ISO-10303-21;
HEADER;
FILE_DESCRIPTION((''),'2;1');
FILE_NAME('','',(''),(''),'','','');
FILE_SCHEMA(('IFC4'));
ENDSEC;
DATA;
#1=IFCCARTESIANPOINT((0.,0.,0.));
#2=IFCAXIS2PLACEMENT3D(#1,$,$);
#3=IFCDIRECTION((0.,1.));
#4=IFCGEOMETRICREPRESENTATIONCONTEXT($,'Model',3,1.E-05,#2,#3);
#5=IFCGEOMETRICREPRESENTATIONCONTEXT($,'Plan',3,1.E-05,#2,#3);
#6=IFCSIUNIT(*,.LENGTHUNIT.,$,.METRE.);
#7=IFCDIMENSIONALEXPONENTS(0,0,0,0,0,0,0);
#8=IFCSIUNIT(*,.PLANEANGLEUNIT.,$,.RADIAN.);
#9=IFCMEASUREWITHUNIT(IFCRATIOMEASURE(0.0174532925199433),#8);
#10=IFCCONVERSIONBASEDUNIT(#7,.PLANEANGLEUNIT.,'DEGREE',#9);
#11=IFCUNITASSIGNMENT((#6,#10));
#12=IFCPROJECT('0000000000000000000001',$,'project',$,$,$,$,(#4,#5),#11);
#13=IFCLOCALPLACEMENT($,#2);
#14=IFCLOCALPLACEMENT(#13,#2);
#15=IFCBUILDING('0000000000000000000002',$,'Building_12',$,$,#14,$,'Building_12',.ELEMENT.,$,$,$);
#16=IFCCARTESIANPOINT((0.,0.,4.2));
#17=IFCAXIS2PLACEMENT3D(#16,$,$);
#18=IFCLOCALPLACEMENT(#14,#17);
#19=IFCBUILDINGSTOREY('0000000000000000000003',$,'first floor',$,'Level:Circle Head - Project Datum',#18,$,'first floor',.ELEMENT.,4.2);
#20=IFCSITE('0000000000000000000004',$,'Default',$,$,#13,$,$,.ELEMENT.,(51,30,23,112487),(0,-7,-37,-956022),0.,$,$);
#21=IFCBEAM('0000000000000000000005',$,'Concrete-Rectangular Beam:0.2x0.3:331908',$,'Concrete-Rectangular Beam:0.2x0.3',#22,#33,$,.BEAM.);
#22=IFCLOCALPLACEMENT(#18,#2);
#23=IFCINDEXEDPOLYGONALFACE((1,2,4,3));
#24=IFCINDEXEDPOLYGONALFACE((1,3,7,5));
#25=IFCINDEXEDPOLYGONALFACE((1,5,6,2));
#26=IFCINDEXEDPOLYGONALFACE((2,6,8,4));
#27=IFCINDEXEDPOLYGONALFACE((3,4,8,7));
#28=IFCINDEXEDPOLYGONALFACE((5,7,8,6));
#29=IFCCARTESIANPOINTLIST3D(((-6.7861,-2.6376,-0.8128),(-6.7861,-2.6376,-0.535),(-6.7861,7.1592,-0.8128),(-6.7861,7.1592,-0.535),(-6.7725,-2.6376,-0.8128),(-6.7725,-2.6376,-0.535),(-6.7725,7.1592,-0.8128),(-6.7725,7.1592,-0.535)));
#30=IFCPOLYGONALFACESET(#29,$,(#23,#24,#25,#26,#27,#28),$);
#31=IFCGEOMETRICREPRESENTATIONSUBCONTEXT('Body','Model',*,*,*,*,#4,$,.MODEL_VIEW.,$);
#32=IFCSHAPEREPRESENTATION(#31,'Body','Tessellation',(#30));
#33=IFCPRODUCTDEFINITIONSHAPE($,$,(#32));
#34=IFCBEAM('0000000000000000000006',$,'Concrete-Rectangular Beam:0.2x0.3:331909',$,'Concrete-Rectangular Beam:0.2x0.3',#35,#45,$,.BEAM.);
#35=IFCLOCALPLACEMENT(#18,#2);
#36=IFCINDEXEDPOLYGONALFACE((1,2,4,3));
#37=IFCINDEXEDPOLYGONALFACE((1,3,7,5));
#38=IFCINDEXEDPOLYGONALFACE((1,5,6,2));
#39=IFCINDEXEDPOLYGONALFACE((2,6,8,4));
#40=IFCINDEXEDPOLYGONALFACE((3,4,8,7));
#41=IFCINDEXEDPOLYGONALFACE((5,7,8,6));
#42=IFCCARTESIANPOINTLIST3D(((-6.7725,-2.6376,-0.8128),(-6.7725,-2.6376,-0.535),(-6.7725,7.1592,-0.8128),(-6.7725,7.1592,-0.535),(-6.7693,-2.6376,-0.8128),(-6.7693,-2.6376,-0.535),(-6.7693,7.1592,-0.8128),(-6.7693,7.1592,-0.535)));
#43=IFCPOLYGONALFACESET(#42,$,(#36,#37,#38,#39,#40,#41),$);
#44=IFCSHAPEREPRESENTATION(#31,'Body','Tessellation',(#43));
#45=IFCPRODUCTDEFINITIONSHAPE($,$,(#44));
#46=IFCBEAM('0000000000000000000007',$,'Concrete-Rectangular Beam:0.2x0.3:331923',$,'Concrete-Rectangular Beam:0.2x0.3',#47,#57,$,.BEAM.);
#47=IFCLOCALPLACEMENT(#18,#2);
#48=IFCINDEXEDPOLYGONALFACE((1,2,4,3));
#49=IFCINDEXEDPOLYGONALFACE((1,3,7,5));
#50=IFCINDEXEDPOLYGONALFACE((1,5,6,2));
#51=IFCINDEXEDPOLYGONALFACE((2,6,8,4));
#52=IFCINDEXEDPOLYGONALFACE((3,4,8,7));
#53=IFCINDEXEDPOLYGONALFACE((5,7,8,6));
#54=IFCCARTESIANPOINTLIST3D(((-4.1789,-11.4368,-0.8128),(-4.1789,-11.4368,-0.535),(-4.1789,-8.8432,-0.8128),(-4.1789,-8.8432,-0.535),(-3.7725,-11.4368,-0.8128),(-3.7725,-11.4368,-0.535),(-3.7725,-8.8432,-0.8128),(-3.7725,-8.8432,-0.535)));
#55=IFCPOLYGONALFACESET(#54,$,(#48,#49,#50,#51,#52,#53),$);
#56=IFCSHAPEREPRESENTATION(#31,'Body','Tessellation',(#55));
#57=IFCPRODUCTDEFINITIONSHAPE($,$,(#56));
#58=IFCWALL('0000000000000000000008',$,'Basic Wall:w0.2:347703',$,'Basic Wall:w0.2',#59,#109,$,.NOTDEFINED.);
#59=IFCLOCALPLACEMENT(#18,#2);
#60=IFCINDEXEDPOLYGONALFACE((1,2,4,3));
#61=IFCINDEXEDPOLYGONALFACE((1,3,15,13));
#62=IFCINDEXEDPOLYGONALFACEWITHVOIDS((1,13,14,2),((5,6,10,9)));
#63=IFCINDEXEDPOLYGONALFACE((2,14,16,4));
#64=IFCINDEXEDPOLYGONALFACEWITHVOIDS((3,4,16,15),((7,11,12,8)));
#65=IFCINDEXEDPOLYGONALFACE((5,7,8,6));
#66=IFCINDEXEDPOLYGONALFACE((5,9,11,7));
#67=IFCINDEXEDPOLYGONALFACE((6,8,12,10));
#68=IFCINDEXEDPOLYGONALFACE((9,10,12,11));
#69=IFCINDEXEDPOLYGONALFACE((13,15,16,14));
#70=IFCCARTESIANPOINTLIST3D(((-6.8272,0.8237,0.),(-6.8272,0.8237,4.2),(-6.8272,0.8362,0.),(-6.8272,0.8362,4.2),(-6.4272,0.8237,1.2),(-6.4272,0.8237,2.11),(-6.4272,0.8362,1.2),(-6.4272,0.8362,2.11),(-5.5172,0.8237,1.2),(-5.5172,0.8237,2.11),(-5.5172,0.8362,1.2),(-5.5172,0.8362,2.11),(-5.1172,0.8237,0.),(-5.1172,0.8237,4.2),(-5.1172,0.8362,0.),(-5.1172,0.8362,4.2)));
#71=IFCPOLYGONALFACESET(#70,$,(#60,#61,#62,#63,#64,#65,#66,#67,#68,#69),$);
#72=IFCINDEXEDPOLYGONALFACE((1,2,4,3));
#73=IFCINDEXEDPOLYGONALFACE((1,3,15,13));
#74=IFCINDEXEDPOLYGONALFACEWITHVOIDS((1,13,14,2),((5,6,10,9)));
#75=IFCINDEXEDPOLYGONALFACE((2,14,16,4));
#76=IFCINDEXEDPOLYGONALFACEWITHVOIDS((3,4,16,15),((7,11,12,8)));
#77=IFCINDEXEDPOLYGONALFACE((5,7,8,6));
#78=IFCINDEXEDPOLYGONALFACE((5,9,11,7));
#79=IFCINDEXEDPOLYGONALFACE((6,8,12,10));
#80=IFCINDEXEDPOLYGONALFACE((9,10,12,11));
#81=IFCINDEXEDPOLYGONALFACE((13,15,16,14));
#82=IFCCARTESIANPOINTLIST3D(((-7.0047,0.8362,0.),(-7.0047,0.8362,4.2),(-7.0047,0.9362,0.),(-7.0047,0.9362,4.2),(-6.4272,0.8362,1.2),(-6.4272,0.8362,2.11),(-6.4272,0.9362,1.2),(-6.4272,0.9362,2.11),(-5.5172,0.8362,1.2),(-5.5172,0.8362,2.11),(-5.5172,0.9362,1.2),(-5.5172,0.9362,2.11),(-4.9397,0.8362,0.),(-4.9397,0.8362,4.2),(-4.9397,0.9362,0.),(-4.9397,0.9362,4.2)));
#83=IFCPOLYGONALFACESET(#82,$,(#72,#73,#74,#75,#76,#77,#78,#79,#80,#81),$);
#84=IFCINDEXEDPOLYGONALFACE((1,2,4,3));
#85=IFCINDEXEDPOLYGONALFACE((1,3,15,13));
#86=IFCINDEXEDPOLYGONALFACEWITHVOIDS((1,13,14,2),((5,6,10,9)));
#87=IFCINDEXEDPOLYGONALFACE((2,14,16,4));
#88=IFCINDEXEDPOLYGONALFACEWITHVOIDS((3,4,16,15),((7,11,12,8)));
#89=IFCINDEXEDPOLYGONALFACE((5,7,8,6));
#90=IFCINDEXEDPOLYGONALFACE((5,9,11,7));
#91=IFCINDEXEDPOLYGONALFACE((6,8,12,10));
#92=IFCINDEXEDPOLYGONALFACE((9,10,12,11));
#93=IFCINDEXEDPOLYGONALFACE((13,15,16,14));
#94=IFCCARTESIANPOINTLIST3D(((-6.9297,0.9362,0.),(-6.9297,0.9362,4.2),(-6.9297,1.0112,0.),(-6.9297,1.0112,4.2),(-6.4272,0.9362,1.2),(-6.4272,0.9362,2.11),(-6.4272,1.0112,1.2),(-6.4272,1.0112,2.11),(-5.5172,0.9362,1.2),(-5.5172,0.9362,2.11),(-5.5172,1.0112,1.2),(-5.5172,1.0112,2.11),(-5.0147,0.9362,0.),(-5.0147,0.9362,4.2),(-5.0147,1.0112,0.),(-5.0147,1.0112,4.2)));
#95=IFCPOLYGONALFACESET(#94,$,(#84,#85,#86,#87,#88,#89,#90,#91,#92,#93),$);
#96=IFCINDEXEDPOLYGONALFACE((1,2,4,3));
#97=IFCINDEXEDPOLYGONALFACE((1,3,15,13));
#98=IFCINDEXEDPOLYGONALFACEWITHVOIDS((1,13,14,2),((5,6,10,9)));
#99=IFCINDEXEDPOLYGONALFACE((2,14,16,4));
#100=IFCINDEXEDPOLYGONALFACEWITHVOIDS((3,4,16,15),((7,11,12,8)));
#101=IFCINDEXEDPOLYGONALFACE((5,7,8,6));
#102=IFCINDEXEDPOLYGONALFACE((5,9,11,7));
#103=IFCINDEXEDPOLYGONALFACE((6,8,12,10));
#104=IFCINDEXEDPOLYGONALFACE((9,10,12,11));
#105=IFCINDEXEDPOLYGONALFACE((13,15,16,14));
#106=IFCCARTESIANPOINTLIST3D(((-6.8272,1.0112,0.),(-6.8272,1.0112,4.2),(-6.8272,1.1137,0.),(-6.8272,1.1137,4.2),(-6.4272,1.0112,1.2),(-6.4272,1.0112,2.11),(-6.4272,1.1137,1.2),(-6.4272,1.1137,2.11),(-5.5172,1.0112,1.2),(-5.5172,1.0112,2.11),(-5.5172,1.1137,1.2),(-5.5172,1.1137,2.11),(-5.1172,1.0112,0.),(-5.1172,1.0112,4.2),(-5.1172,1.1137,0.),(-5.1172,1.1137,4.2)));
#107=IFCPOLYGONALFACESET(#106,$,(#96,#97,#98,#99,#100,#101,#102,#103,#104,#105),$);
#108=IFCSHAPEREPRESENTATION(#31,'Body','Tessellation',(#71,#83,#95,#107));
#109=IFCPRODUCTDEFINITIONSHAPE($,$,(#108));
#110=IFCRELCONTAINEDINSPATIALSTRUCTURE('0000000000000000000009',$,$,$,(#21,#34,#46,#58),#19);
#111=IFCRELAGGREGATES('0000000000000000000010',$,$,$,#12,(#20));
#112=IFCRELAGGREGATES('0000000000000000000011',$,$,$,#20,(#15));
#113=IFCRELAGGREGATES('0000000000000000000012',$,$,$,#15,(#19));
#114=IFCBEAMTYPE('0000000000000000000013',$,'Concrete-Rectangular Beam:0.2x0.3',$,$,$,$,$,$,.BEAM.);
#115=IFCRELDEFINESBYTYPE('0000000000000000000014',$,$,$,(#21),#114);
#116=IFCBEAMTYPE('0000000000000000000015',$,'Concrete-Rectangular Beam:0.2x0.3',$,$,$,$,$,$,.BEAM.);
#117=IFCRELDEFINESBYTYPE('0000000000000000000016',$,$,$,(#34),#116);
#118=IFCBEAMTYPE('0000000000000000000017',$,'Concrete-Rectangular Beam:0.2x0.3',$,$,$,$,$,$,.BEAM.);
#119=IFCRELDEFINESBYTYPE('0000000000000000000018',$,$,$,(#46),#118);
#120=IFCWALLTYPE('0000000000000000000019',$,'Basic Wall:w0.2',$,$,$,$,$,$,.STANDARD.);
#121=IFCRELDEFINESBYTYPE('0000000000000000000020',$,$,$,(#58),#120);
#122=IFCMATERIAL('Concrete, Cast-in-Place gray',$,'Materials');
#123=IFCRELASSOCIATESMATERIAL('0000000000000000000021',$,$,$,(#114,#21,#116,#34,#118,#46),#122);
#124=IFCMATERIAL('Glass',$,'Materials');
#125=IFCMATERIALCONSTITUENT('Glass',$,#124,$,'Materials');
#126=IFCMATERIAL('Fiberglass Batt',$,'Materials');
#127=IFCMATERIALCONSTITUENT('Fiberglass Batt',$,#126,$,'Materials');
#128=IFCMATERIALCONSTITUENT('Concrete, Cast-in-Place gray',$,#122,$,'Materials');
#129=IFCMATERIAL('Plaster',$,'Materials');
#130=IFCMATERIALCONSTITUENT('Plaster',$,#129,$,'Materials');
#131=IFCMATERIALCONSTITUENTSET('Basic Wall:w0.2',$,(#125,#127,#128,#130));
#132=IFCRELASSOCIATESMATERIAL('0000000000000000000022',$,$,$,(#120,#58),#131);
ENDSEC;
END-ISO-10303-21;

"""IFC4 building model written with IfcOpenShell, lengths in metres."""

from ifc_helpers import new_model, entity, si_unit, converted_unit, direction, frame, origin, place, context, subcontext, project, spatial, indexed_curve, outline, extrude, source, transform, mapped, material, constituent, constituent_set, type_object, type_shapes, element, save


model = new_model("IFC4")

# Units and contexts
model_context = context("Model", 3, precision=1e-05, world=origin(), true_north=direction((0.0, 1.0)))
plan_context = context("Plan", 3, precision=1e-05, world=origin(), true_north=direction((0.0, 1.0)))
body_context = subcontext(model_context, "Body", "Model", "MODEL_VIEW")
ifc_project = project(units=[si_unit("LENGTHUNIT", "METRE"), converted_unit("PLANEANGLEUNIT", "DEGREE", entity("IfcRatioMeasure", 0.0174532925199433), si_unit("PLANEANGLEUNIT", "RADIAN"), dimensions=[0, 0, 0, 0, 0, 0, 0])], contexts=[model_context, plan_context])

# Site, building, storey
site_placement = place(None, origin())
site = spatial("IfcSite", under=ifc_project, at=site_placement, Name="Default", CompositionType="ELEMENT", RefLatitude=(51, 30, 23, 112487), RefLongitude=(0, -7, -37, -956022), RefElevation=0.0)
building_placement = place(site_placement, origin())
building = spatial("IfcBuilding", under=site, at=building_placement, Name="Building_12", LongName="Building_12", CompositionType="ELEMENT")
storey_placement = place(building_placement, frame((0.0, 0.0, 4.2)))
storey = spatial("IfcBuildingStorey", under=building, at=storey_placement, Name="first floor", ObjectType="Level:Circle Head - Project Datum", LongName="first floor", CompositionType="ELEMENT", Elevation=4.2)

# Shared definitions
ifc_material_1 = material(Name="Glass", Category="Materials")
ifc_material_2 = material(Name="Plaster", Category="Materials")

# Beams
ifc_material_3 = material(Name="Concrete, Cast-in-Place gray", Category="Materials")
beam_type_1 = type_object("IfcBeamType", Name="Concrete-Rectangular Beam:0.2x0.3", PredefinedType="BEAM", material=ifc_material_3)
shared_shape_1 = source(origin(), body_context, "Body", "SweptSolid", [
    extrude(outline(indexed_curve([(-0.0068, -0.1389), (0.0068, -0.1389), (0.0068, 0.1389), (-0.0068, 0.1389), (-0.0068, -0.1389)], self_intersect=False)), frame((-6.7793, 7.1592, 3.5261), z_axis=(0.0, -1.0, 0.0), x_axis=(-1.0, 0.0, 0.0)), (0.0, 0.0, 1.0), 9.7968),
])
type_shapes(beam_type_1, [shared_shape_1])
beam_1_placement = place(storey_placement, frame((0.0, 0.0, -4.2)))
element("IfcBeam", 1, at=beam_1_placement, inside=storey, type_object=beam_type_1, material=ifc_material_3, Name="Concrete-Rectangular Beam:0.2x0.3:331908", ObjectType="Concrete-Rectangular Beam:0.2x0.3", PredefinedType="BEAM", context=body_context, shape_type="MappedRepresentation", body=[
    mapped(shared_shape_1, transform((0.0, 0.0, 0.0), scale=1.0)),
])
beam_type_2 = type_object("IfcBeamType", Name="Concrete-Rectangular Beam:0.2x0.3", PredefinedType="BEAM", material=ifc_material_3)
shared_shape_2 = source(origin(), body_context, "Body", "SweptSolid", [
    extrude(outline(indexed_curve([(-0.0016, -0.1389), (0.0016, -0.1389), (0.0016, 0.1389), (-0.0016, 0.1389), (-0.0016, -0.1389)], self_intersect=False)), frame((-6.7709, 7.1592, 3.5261), z_axis=(0.0, -1.0, 0.0), x_axis=(-1.0, 0.0, 0.0)), (0.0, 0.0, 1.0), 9.7968),
])
type_shapes(beam_type_2, [shared_shape_2])
beam_2_placement = place(storey_placement, frame((0.0, 0.0, -4.2)))
element("IfcBeam", 2, at=beam_2_placement, inside=storey, type_object=beam_type_2, material=ifc_material_3, Name="Concrete-Rectangular Beam:0.2x0.3:331909", ObjectType="Concrete-Rectangular Beam:0.2x0.3", PredefinedType="BEAM", context=body_context, shape_type="MappedRepresentation", body=[
    mapped(shared_shape_2, transform((0.0, 0.0, 0.0), scale=1.0)),
])
beam_type_3 = type_object("IfcBeamType", Name="Concrete-Rectangular Beam:0.2x0.3", PredefinedType="BEAM", material=ifc_material_3)
shared_shape_3 = source(origin(), body_context, "Body", "SweptSolid", [
    extrude(outline(indexed_curve([(-0.2032, -0.1389), (0.2032, -0.1389), (0.2032, 0.1389), (-0.2032, 0.1389), (-0.2032, -0.1389)], self_intersect=False)), frame((-3.9757, -8.8432, 3.5261), z_axis=(0.0, -1.0, 0.0), x_axis=(-1.0, 0.0, 0.0)), (0.0, 0.0, 1.0), 2.5936),
])
type_shapes(beam_type_3, [shared_shape_3])
beam_3_placement = place(storey_placement, frame((0.0, 0.0, -4.2)))
element("IfcBeam", 3, at=beam_3_placement, inside=storey, type_object=beam_type_3, material=ifc_material_3, Name="Concrete-Rectangular Beam:0.2x0.3:331923", ObjectType="Concrete-Rectangular Beam:0.2x0.3", PredefinedType="BEAM", context=body_context, shape_type="MappedRepresentation", body=[
    mapped(shared_shape_3, transform((0.0, 0.0, 0.0), scale=1.0)),
])

# Wall, opening
ifc_constituent_1 = constituent(ifc_material_1, Name="Glass", Category="Materials")
ifc_material_4 = material(Name="Fiberglass Batt", Category="Materials")
ifc_constituent_2 = constituent(ifc_material_4, Name="Fiberglass Batt", Category="Materials")
ifc_constituent_3 = constituent(ifc_material_3, Name="Concrete, Cast-in-Place gray", Category="Materials")
ifc_constituent_4 = constituent(ifc_material_2, Name="Plaster", Category="Materials")
ifc_constituent_set_1 = constituent_set(constituents=[ifc_constituent_1, ifc_constituent_2, ifc_constituent_3, ifc_constituent_4], Name="Basic Wall:w0.2")
wall_type_1 = type_object("IfcWallType", Name="Basic Wall:w0.2", PredefinedType="STANDARD", material=ifc_constituent_set_1)
wall_1_placement = place(storey_placement, frame((-6.8272, 0.9687, 0.0)))
wall_1 = element("IfcWall", 4, at=wall_1_placement, inside=storey, type_object=wall_type_1, material=ifc_constituent_set_1, Name="Basic Wall:w0.2:347703", ObjectType="Basic Wall:w0.2", PredefinedType="NOTDEFINED", context=body_context, shape_type="SweptSolid", body=[
    extrude(outline(indexed_curve([(-2.1, -0.855), (2.1, -0.855), (2.1, 0.855), (-2.1, 0.855), (-2.1, -0.855)], self_intersect=False), holes=[indexed_curve([(0.01, -0.455), (-0.9, -0.455), (-0.9, 0.455), (0.01, 0.455), (0.01, -0.455)], self_intersect=False)]), frame((0.855, -0.145, 2.1), z_axis=(0.0, 1.0, 0.0), x_axis=(0.0, 0.0, 1.0)), (0.0, 0.0, 1.0), 0.0125),
    extrude(outline(indexed_curve([(-2.1, -1.0325), (2.1, -1.0325), (2.1, 1.0325), (-2.1, 1.0325), (-2.1, -1.0325)], self_intersect=False), holes=[indexed_curve([(-0.9, -0.455), (-0.9, 0.455), (0.01, 0.455), (0.01, -0.455), (-0.9, -0.455)], self_intersect=False)]), frame((0.855, -0.1325, 2.1), z_axis=(0.0, 1.0, 0.0), x_axis=(0.0, 0.0, 1.0)), (0.0, 0.0, 1.0), 0.1),
    extrude(outline(indexed_curve([(-2.1, -0.9575), (2.1, -0.9575), (2.1, 0.9575), (-2.1, 0.9575), (-2.1, -0.9575)], self_intersect=False), holes=[indexed_curve([(-0.9, -0.455), (-0.9, 0.455), (0.01, 0.455), (0.01, -0.455), (-0.9, -0.455)], self_intersect=False)]), frame((0.855, -0.0325, 2.1), z_axis=(0.0, 1.0, 0.0), x_axis=(0.0, 0.0, 1.0)), (0.0, 0.0, 1.0), 0.075),
    extrude(outline(indexed_curve([(-2.1, -0.855), (2.1, -0.855), (2.1, 0.855), (-2.1, 0.855), (-2.1, -0.855)], self_intersect=False), holes=[indexed_curve([(-0.9, -0.455), (-0.9, 0.455), (0.01, 0.455), (0.01, -0.455), (-0.9, -0.455)], self_intersect=False)]), frame((0.855, 0.0425, 2.1), z_axis=(0.0, 1.0, 0.0), x_axis=(0.0, 0.0, 1.0)), (0.0, 0.0, 1.0), 0.1025),
])
opening_1_placement = place(wall_1_placement, frame((0.4, -0.145, 1.2)))
element("IfcOpeningElement", 5, at=opening_1_placement, cuts=wall_1, PredefinedType="OPENING", context=body_context, shape_type="SweptSolid", body=[
    extrude(outline(indexed_curve([(0.91, 0.0), (0.91, 0.91), (0.0, 0.91), (0.0, 0.0), (0.91, 0.0)], self_intersect=False)), frame((0.0, 0.0, 0.0), z_axis=(0.0, 1.0, 0.0), x_axis=(0.0, 0.0, 1.0)), (0.0, 0.0, 1.0), 0.29),
])

save(model, "model.ifc")
